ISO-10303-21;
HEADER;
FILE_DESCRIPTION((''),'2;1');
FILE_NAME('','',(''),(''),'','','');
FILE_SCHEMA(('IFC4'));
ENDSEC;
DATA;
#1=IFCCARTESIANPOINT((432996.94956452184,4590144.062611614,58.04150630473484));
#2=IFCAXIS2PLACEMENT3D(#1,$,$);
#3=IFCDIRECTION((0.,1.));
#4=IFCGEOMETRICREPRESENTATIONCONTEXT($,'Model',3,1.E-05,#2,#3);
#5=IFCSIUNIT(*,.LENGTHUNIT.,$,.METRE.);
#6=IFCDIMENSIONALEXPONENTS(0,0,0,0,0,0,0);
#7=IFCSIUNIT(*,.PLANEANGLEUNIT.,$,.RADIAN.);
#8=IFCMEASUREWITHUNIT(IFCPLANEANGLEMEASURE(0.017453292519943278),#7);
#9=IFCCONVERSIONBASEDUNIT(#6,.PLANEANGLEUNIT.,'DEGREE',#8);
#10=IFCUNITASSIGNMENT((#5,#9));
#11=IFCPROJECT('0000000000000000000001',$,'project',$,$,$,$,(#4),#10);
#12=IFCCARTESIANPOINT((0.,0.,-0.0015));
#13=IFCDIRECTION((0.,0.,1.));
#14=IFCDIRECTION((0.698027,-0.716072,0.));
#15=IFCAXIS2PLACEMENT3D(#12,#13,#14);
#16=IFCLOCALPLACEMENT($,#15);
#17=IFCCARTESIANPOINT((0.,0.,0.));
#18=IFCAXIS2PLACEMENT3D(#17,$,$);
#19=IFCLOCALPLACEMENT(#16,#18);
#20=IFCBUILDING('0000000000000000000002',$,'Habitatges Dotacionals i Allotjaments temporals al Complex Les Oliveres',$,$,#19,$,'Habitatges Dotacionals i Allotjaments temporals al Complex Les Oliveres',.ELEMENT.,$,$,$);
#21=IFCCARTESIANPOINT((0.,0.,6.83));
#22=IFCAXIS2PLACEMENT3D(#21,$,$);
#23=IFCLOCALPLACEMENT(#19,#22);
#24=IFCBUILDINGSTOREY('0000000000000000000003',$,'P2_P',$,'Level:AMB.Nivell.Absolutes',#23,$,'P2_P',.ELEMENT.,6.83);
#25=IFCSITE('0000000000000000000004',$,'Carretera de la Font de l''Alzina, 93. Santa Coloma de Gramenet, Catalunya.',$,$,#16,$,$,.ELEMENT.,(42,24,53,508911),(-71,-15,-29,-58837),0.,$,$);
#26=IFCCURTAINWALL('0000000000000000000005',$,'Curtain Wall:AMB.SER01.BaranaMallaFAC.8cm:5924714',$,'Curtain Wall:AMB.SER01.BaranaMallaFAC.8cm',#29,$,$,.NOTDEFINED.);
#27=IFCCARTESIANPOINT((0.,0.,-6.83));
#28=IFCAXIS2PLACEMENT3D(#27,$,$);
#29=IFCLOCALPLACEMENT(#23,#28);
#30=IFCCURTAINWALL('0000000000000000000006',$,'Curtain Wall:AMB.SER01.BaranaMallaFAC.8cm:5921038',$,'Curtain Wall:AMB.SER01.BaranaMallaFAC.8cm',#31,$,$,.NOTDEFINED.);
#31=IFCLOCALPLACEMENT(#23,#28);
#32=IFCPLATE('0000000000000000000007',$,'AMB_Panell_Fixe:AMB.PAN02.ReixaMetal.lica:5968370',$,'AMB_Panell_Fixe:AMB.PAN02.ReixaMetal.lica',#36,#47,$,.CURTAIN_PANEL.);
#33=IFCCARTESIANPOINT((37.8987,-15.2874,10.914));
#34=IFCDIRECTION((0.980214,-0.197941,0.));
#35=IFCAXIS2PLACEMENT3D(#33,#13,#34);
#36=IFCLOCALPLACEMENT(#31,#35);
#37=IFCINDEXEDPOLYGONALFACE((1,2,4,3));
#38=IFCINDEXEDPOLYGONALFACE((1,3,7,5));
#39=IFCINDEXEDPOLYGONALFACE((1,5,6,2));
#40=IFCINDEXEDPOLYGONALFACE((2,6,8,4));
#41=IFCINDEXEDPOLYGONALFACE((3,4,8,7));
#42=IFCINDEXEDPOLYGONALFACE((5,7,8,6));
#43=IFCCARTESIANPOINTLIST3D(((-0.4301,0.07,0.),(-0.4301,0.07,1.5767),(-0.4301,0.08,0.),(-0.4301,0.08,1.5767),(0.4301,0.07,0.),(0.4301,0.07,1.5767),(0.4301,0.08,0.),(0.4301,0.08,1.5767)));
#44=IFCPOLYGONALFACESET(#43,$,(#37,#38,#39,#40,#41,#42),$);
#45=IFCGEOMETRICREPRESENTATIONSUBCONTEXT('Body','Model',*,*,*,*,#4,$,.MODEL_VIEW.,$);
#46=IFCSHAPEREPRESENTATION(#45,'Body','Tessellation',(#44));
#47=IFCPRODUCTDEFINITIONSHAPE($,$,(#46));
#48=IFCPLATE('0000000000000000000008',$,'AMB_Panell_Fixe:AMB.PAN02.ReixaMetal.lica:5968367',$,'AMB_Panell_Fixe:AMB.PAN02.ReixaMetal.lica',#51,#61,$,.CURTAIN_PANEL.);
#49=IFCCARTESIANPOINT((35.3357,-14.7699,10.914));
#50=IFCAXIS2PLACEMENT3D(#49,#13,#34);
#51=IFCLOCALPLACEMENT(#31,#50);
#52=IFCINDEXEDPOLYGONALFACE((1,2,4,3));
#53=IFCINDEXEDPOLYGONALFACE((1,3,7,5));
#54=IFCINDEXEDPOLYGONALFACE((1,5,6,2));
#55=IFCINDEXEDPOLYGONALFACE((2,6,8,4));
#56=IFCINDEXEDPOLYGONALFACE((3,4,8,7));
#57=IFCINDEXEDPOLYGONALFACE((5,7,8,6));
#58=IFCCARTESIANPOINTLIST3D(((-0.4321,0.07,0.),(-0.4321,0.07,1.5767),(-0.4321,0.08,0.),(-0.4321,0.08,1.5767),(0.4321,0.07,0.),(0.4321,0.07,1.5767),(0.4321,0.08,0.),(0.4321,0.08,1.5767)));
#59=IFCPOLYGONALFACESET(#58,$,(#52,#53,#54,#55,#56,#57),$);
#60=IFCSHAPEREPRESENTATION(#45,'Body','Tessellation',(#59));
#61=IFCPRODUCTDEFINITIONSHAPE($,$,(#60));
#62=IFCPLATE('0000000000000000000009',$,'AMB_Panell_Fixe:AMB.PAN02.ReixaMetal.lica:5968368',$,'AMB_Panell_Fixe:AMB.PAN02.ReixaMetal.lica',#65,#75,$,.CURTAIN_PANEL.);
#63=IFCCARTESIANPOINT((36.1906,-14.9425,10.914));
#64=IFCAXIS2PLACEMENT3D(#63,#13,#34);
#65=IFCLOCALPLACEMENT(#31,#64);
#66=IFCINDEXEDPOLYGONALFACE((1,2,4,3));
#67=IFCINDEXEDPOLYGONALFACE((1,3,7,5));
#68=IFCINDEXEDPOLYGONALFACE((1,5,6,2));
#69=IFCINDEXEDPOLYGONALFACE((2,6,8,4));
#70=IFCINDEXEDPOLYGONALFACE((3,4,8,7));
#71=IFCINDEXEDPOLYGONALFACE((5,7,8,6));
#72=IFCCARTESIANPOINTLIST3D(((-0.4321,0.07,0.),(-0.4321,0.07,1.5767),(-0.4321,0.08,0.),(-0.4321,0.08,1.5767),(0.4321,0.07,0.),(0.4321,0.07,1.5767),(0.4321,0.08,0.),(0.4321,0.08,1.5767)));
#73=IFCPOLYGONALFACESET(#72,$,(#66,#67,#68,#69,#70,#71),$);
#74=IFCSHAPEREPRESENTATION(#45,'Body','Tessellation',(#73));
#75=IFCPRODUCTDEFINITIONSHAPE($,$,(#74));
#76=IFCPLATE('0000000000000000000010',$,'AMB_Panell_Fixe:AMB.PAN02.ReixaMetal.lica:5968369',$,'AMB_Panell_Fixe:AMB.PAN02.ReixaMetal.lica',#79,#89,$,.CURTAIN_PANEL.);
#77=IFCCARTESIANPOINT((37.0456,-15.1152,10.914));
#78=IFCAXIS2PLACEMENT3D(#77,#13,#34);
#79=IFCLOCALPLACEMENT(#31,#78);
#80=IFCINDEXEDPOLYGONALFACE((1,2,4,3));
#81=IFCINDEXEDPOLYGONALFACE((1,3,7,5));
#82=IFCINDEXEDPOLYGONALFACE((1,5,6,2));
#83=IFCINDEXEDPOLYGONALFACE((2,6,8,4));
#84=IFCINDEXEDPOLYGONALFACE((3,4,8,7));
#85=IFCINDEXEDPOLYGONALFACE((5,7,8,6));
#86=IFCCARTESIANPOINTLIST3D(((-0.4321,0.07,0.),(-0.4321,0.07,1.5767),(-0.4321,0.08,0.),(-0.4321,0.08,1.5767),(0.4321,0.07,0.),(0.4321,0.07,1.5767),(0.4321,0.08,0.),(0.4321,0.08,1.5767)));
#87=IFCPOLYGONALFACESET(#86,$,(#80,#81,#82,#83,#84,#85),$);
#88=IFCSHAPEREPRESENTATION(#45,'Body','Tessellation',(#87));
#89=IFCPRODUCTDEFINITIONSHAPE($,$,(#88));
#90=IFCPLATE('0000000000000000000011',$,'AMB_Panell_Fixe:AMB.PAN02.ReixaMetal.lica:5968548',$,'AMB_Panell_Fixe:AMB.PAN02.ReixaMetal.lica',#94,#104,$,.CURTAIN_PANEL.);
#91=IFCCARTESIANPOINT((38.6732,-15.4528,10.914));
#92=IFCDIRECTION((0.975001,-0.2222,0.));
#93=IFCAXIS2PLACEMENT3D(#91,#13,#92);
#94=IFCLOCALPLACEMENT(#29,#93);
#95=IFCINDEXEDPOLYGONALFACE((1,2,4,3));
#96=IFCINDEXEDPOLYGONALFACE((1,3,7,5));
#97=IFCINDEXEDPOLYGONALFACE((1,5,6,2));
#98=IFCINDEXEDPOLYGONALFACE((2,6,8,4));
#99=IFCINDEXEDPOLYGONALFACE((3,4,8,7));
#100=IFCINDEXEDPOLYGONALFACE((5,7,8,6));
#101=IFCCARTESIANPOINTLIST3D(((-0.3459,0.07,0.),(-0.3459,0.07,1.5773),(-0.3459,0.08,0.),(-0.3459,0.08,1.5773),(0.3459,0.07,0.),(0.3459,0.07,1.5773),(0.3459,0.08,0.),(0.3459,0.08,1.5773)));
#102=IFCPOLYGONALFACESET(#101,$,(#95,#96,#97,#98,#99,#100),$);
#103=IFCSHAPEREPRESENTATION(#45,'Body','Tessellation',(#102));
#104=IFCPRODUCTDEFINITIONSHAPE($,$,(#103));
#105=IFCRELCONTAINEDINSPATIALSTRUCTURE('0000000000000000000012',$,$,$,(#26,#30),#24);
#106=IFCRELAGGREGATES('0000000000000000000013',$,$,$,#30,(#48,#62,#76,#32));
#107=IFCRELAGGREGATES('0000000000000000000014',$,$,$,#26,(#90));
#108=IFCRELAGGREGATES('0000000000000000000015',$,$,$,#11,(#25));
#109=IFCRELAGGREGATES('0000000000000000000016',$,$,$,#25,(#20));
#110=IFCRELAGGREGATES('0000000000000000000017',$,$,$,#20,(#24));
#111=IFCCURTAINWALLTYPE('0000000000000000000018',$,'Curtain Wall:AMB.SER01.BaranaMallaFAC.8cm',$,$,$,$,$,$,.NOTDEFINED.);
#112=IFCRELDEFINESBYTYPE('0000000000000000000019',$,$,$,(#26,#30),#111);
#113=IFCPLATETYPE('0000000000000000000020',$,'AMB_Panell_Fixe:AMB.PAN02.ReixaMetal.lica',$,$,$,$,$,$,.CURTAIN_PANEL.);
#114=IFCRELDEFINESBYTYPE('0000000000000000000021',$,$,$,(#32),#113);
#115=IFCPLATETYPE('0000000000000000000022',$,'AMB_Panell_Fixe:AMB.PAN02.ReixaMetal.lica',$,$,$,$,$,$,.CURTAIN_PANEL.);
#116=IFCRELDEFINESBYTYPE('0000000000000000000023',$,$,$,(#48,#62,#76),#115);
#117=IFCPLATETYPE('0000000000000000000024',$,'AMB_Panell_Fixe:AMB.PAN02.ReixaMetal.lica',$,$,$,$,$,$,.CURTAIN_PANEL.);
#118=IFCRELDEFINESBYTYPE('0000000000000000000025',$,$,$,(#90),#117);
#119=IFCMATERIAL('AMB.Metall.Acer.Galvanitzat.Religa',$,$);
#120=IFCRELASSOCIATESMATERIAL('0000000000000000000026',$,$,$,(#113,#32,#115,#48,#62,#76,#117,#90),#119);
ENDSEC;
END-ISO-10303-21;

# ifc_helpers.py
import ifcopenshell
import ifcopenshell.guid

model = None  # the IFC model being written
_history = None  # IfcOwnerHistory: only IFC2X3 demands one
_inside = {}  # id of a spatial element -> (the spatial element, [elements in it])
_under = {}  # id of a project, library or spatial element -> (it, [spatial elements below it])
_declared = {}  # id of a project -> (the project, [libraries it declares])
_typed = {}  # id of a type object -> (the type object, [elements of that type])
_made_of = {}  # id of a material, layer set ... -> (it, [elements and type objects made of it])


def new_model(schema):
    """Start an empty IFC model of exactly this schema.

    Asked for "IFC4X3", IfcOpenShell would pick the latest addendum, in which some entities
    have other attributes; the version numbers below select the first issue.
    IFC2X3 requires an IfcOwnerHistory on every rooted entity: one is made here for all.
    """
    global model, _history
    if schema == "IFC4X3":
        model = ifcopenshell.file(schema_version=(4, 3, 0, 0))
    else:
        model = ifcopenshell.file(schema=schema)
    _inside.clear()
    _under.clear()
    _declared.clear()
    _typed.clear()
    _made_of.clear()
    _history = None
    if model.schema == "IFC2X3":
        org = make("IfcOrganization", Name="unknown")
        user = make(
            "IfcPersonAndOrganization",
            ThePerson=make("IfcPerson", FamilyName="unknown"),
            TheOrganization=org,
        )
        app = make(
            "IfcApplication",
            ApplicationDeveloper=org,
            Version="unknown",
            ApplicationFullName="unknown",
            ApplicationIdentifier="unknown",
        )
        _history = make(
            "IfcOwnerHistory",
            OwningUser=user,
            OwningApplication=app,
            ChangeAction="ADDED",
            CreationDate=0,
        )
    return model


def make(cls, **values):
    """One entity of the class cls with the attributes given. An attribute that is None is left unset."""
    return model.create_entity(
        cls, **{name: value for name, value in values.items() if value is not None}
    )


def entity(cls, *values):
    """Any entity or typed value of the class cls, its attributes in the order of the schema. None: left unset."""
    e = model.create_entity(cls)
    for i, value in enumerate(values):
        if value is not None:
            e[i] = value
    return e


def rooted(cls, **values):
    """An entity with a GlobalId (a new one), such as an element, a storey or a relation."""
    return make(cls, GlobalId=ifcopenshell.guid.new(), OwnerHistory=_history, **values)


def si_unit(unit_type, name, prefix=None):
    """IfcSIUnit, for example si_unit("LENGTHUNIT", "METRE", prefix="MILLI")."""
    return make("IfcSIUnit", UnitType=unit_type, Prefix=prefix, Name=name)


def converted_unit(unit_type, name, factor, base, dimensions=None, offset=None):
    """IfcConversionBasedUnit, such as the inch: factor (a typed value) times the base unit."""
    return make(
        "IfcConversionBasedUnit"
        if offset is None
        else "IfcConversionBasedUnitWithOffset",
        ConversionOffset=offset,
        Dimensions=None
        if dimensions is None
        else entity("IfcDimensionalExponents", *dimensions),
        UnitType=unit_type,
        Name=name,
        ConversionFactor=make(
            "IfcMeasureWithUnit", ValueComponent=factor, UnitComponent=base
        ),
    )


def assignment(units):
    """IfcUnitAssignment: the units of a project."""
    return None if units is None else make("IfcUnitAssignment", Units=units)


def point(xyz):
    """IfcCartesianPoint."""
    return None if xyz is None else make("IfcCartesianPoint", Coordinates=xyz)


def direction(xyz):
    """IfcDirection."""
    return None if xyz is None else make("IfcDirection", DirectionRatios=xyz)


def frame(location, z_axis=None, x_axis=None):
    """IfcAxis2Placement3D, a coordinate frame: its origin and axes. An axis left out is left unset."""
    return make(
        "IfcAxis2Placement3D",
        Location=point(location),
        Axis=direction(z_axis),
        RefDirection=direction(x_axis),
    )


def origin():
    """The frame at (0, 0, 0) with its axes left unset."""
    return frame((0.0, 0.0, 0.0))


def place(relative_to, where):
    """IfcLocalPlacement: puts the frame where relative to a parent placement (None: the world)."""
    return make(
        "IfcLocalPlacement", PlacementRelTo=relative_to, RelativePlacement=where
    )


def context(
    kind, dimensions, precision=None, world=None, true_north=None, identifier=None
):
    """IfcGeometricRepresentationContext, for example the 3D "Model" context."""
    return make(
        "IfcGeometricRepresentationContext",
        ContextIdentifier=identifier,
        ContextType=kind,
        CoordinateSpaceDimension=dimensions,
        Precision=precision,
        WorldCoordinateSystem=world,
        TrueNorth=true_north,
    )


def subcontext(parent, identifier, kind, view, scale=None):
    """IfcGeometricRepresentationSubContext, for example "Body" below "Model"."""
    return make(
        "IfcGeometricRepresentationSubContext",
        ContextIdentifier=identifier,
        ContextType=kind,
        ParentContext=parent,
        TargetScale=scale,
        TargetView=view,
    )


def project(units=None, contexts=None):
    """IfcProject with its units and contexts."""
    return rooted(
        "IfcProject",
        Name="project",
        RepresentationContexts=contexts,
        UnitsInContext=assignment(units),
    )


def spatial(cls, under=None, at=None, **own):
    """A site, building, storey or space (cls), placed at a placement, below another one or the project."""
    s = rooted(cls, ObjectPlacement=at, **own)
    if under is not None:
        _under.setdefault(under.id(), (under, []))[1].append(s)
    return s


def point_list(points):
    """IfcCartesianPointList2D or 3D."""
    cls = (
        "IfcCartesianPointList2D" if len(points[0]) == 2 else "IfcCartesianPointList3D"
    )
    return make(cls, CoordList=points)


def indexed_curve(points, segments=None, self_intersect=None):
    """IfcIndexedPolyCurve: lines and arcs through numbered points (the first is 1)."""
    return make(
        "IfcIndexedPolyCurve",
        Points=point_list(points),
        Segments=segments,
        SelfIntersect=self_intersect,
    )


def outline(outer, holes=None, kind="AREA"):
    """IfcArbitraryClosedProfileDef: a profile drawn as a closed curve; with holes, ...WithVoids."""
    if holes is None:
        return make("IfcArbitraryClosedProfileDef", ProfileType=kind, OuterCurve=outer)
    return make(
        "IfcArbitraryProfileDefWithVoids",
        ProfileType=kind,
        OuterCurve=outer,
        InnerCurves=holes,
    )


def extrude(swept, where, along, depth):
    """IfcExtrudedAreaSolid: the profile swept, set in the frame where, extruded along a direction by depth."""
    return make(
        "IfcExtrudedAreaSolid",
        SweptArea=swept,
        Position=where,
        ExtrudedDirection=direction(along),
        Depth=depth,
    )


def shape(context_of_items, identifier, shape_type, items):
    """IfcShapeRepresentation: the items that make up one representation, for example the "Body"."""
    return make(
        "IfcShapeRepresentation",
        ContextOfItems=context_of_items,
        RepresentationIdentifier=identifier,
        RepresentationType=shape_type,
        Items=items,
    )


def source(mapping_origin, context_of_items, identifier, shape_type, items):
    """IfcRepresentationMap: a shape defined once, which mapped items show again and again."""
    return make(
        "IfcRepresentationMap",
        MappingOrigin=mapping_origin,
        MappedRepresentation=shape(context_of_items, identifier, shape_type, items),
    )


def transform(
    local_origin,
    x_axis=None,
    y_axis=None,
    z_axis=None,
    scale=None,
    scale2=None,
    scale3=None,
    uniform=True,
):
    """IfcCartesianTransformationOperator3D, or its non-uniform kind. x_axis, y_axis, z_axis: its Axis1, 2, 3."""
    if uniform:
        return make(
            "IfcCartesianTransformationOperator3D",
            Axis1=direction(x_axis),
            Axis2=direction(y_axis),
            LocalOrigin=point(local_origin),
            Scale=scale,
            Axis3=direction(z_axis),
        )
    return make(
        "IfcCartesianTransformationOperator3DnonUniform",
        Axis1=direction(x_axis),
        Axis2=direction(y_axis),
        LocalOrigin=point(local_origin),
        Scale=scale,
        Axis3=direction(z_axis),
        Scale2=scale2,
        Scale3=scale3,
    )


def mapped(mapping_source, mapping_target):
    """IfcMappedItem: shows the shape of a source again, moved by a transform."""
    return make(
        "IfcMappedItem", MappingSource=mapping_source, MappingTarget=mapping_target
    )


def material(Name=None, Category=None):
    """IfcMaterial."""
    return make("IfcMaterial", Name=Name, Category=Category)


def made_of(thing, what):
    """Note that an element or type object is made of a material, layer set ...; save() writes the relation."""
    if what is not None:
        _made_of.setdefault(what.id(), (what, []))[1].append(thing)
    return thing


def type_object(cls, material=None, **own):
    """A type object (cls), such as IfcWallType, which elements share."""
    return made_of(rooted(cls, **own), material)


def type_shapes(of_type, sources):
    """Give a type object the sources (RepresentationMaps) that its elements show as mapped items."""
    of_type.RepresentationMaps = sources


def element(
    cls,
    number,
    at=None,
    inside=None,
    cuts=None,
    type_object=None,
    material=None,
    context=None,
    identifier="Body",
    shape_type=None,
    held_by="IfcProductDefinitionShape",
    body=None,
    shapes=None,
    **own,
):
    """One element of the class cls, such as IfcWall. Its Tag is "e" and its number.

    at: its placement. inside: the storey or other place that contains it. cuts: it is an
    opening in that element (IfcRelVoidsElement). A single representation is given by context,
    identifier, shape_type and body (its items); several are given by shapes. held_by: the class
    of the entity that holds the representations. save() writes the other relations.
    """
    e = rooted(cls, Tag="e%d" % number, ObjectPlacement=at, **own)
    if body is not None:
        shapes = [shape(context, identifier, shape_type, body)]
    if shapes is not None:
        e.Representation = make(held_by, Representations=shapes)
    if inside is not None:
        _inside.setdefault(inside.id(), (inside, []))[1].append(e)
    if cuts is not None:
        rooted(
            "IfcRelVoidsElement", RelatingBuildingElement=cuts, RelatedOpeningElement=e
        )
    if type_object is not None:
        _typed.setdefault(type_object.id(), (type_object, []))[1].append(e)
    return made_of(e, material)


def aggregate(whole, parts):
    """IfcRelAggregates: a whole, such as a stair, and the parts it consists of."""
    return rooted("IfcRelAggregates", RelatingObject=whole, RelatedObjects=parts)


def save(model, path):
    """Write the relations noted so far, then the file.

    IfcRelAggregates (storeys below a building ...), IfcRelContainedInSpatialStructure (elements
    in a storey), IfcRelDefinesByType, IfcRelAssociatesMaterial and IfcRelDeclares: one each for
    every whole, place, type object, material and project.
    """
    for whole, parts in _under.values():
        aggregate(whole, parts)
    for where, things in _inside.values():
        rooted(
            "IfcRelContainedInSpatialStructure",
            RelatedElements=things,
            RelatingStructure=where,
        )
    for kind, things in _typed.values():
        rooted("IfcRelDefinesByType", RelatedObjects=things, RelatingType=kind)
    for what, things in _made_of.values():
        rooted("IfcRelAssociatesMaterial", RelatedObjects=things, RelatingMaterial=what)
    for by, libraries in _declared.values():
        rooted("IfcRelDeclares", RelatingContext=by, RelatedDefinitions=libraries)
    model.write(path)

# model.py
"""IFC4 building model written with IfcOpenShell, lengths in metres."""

from ifc_helpers import new_model, entity, si_unit, converted_unit, direction, frame, origin, place, context, subcontext, project, spatial, indexed_curve, outline, extrude, source, transform, mapped, material, type_object, type_shapes, element, aggregate, save


model = new_model("IFC4")

# Units and contexts
model_context = context("Model", 3, precision=1e-05, world=frame((432996.94956452184, 4590144.062611614, 58.04150630473484)), true_north=direction((0.0, 1.0)))
body_context = subcontext(model_context, "Body", "Model", "MODEL_VIEW")
ifc_project = project(units=[si_unit("LENGTHUNIT", "METRE"), converted_unit("PLANEANGLEUNIT", "DEGREE", entity("IfcPlaneAngleMeasure", 0.017453292519943278), si_unit("PLANEANGLEUNIT", "RADIAN"), dimensions=[0, 0, 0, 0, 0, 0, 0])], contexts=[model_context])

# Site, building, storey
site_placement = place(None, frame((0.0, 0.0, -0.0015), z_axis=(0.0, 0.0, 1.0), x_axis=(0.698027, -0.716072, 0.0)))
site = spatial("IfcSite", under=ifc_project, at=site_placement, Name="Carretera de la Font de l'Alzina, 93. Santa Coloma de Gramenet, Catalunya.", CompositionType="ELEMENT", RefLatitude=(42, 24, 53, 508911), RefLongitude=(-71, -15, -29, -58837), RefElevation=0.0)
building_placement = place(site_placement, origin())
building = spatial("IfcBuilding", under=site, at=building_placement, Name="Habitatges Dotacionals i Allotjaments temporals al Complex Les Oliveres", LongName="Habitatges Dotacionals i Allotjaments temporals al Complex Les Oliveres", CompositionType="ELEMENT")
storey_placement = place(building_placement, frame((0.0, 0.0, 6.83)))
storey = spatial("IfcBuildingStorey", under=building, at=storey_placement, Name="P2_P", ObjectType="Level:AMB.Nivell.Absolutes", LongName="P2_P", CompositionType="ELEMENT", Elevation=6.83)

# Curtain wall
curtain_wall_type = type_object("IfcCurtainWallType", Name="Curtain Wall:AMB.SER01.BaranaMallaFAC.8cm", PredefinedType="NOTDEFINED")
curtain_wall_1_placement = place(storey_placement, frame((0.0, 0.0, -6.83)))
curtain_wall_1 = element("IfcCurtainWall", 1, at=curtain_wall_1_placement, inside=storey, type_object=curtain_wall_type, Name="Curtain Wall:AMB.SER01.BaranaMallaFAC.8cm:5924714", ObjectType="Curtain Wall:AMB.SER01.BaranaMallaFAC.8cm", PredefinedType="NOTDEFINED")

# Curtain wall
curtain_wall_2_placement = place(storey_placement, frame((0.0, 0.0, -6.83)))
curtain_wall_2 = element("IfcCurtainWall", 2, at=curtain_wall_2_placement, inside=storey, type_object=curtain_wall_type, Name="Curtain Wall:AMB.SER01.BaranaMallaFAC.8cm:5921038", ObjectType="Curtain Wall:AMB.SER01.BaranaMallaFAC.8cm", PredefinedType="NOTDEFINED")

# Plates
ifc_material_1 = material(Name="AMB.Metall.Acer.Galvanitzat.Religa")
plate_type_1 = type_object("IfcPlateType", Name="AMB_Panell_Fixe:AMB.PAN02.ReixaMetal.lica", PredefinedType="CURTAIN_PANEL", material=ifc_material_1)
shared_shape_1 = source(origin(), body_context, "Body", "SweptSolid", [
    extrude(outline(indexed_curve([(-0.005, -0.4301), (0.005, -0.4301), (0.005, 0.4301), (-0.005, 0.4301), (-0.005, -0.4301)], self_intersect=False)), frame((0.0, 0.075, 0.0), z_axis=(0.0, 0.0, 1.0), x_axis=(0.0, 1.0, 0.0)), (0.0, 0.0, 1.0), 1.5767),
])
type_shapes(plate_type_1, [shared_shape_1])
plate_1_placement = place(curtain_wall_2_placement, frame((37.8987, -15.2874, 10.914), z_axis=(0.0, 0.0, 1.0), x_axis=(0.980214, -0.197941, 0.0)))
plate_1 = element("IfcPlate", 3, at=plate_1_placement, type_object=plate_type_1, material=ifc_material_1, Name="AMB_Panell_Fixe:AMB.PAN02.ReixaMetal.lica:5968370", ObjectType="AMB_Panell_Fixe:AMB.PAN02.ReixaMetal.lica", PredefinedType="CURTAIN_PANEL", context=body_context, shape_type="MappedRepresentation", body=[
    mapped(shared_shape_1, transform((0.0, 0.0, 0.0), scale=1.0)),
])
plate_type_2 = type_object("IfcPlateType", Name="AMB_Panell_Fixe:AMB.PAN02.ReixaMetal.lica", PredefinedType="CURTAIN_PANEL", material=ifc_material_1)
shared_shape_2 = source(origin(), body_context, "Body", "SweptSolid", [
    extrude(outline(indexed_curve([(-0.005, -0.4321), (0.005, -0.4321), (0.005, 0.4321), (-0.005, 0.4321), (-0.005, -0.4321)], self_intersect=False)), frame((0.0, 0.075, 0.0), z_axis=(0.0, 0.0, 1.0), x_axis=(0.0, 1.0, 0.0)), (0.0, 0.0, 1.0), 1.5767),
])
type_shapes(plate_type_2, [shared_shape_2])
plate_2_placement = place(curtain_wall_2_placement, frame((35.3357, -14.7699, 10.914), z_axis=(0.0, 0.0, 1.0), x_axis=(0.980214, -0.197941, 0.0)))
plate_2 = element("IfcPlate", 4, at=plate_2_placement, type_object=plate_type_2, material=ifc_material_1, Name="AMB_Panell_Fixe:AMB.PAN02.ReixaMetal.lica:5968367", ObjectType="AMB_Panell_Fixe:AMB.PAN02.ReixaMetal.lica", PredefinedType="CURTAIN_PANEL", context=body_context, shape_type="MappedRepresentation", body=[
    mapped(shared_shape_2, transform((0.0, 0.0, 0.0), scale=1.0)),
])
plate_3_placement = place(curtain_wall_2_placement, frame((36.1906, -14.9425, 10.914), z_axis=(0.0, 0.0, 1.0), x_axis=(0.980214, -0.197941, 0.0)))
plate_3 = element("IfcPlate", 5, at=plate_3_placement, type_object=plate_type_2, material=ifc_material_1, Name="AMB_Panell_Fixe:AMB.PAN02.ReixaMetal.lica:5968368", ObjectType="AMB_Panell_Fixe:AMB.PAN02.ReixaMetal.lica", PredefinedType="CURTAIN_PANEL", context=body_context, shape_type="MappedRepresentation", body=[
    mapped(shared_shape_2, transform((0.0, 0.0, 0.0), scale=1.0)),
])
plate_4_placement = place(curtain_wall_2_placement, frame((37.0456, -15.1152, 10.914), z_axis=(0.0, 0.0, 1.0), x_axis=(0.980214, -0.197941, 0.0)))
plate_4 = element("IfcPlate", 6, at=plate_4_placement, type_object=plate_type_2, material=ifc_material_1, Name="AMB_Panell_Fixe:AMB.PAN02.ReixaMetal.lica:5968369", ObjectType="AMB_Panell_Fixe:AMB.PAN02.ReixaMetal.lica", PredefinedType="CURTAIN_PANEL", context=body_context, shape_type="MappedRepresentation", body=[
    mapped(shared_shape_2, transform((0.0, 0.0, 0.0), scale=1.0)),
])
aggregate(curtain_wall_2, [plate_2, plate_3, plate_4, plate_1])
plate_type_3 = type_object("IfcPlateType", Name="AMB_Panell_Fixe:AMB.PAN02.ReixaMetal.lica", PredefinedType="CURTAIN_PANEL", material=ifc_material_1)
shared_shape_3 = source(origin(), body_context, "Body", "SweptSolid", [
    extrude(outline(indexed_curve([(-0.005, -0.3459), (0.005, -0.3459), (0.005, 0.3459), (-0.005, 0.3459), (-0.005, -0.3459)], self_intersect=False)), frame((0.0, 0.075, 0.0), z_axis=(0.0, 0.0, 1.0), x_axis=(0.0, 1.0, 0.0)), (0.0, 0.0, 1.0), 1.5773),
])
type_shapes(plate_type_3, [shared_shape_3])
plate_5_placement = place(curtain_wall_1_placement, frame((38.6732, -15.4528, 10.914), z_axis=(0.0, 0.0, 1.0), x_axis=(0.975001, -0.2222, 0.0)))
plate_5 = element("IfcPlate", 7, at=plate_5_placement, type_object=plate_type_3, material=ifc_material_1, Name="AMB_Panell_Fixe:AMB.PAN02.ReixaMetal.lica:5968548", ObjectType="AMB_Panell_Fixe:AMB.PAN02.ReixaMetal.lica", PredefinedType="CURTAIN_PANEL", context=body_context, shape_type="MappedRepresentation", body=[
    mapped(shared_shape_3, transform((0.0, 0.0, 0.0), scale=1.0)),
])
aggregate(curtain_wall_1, [plate_5])

save(model, "model.ifc")
